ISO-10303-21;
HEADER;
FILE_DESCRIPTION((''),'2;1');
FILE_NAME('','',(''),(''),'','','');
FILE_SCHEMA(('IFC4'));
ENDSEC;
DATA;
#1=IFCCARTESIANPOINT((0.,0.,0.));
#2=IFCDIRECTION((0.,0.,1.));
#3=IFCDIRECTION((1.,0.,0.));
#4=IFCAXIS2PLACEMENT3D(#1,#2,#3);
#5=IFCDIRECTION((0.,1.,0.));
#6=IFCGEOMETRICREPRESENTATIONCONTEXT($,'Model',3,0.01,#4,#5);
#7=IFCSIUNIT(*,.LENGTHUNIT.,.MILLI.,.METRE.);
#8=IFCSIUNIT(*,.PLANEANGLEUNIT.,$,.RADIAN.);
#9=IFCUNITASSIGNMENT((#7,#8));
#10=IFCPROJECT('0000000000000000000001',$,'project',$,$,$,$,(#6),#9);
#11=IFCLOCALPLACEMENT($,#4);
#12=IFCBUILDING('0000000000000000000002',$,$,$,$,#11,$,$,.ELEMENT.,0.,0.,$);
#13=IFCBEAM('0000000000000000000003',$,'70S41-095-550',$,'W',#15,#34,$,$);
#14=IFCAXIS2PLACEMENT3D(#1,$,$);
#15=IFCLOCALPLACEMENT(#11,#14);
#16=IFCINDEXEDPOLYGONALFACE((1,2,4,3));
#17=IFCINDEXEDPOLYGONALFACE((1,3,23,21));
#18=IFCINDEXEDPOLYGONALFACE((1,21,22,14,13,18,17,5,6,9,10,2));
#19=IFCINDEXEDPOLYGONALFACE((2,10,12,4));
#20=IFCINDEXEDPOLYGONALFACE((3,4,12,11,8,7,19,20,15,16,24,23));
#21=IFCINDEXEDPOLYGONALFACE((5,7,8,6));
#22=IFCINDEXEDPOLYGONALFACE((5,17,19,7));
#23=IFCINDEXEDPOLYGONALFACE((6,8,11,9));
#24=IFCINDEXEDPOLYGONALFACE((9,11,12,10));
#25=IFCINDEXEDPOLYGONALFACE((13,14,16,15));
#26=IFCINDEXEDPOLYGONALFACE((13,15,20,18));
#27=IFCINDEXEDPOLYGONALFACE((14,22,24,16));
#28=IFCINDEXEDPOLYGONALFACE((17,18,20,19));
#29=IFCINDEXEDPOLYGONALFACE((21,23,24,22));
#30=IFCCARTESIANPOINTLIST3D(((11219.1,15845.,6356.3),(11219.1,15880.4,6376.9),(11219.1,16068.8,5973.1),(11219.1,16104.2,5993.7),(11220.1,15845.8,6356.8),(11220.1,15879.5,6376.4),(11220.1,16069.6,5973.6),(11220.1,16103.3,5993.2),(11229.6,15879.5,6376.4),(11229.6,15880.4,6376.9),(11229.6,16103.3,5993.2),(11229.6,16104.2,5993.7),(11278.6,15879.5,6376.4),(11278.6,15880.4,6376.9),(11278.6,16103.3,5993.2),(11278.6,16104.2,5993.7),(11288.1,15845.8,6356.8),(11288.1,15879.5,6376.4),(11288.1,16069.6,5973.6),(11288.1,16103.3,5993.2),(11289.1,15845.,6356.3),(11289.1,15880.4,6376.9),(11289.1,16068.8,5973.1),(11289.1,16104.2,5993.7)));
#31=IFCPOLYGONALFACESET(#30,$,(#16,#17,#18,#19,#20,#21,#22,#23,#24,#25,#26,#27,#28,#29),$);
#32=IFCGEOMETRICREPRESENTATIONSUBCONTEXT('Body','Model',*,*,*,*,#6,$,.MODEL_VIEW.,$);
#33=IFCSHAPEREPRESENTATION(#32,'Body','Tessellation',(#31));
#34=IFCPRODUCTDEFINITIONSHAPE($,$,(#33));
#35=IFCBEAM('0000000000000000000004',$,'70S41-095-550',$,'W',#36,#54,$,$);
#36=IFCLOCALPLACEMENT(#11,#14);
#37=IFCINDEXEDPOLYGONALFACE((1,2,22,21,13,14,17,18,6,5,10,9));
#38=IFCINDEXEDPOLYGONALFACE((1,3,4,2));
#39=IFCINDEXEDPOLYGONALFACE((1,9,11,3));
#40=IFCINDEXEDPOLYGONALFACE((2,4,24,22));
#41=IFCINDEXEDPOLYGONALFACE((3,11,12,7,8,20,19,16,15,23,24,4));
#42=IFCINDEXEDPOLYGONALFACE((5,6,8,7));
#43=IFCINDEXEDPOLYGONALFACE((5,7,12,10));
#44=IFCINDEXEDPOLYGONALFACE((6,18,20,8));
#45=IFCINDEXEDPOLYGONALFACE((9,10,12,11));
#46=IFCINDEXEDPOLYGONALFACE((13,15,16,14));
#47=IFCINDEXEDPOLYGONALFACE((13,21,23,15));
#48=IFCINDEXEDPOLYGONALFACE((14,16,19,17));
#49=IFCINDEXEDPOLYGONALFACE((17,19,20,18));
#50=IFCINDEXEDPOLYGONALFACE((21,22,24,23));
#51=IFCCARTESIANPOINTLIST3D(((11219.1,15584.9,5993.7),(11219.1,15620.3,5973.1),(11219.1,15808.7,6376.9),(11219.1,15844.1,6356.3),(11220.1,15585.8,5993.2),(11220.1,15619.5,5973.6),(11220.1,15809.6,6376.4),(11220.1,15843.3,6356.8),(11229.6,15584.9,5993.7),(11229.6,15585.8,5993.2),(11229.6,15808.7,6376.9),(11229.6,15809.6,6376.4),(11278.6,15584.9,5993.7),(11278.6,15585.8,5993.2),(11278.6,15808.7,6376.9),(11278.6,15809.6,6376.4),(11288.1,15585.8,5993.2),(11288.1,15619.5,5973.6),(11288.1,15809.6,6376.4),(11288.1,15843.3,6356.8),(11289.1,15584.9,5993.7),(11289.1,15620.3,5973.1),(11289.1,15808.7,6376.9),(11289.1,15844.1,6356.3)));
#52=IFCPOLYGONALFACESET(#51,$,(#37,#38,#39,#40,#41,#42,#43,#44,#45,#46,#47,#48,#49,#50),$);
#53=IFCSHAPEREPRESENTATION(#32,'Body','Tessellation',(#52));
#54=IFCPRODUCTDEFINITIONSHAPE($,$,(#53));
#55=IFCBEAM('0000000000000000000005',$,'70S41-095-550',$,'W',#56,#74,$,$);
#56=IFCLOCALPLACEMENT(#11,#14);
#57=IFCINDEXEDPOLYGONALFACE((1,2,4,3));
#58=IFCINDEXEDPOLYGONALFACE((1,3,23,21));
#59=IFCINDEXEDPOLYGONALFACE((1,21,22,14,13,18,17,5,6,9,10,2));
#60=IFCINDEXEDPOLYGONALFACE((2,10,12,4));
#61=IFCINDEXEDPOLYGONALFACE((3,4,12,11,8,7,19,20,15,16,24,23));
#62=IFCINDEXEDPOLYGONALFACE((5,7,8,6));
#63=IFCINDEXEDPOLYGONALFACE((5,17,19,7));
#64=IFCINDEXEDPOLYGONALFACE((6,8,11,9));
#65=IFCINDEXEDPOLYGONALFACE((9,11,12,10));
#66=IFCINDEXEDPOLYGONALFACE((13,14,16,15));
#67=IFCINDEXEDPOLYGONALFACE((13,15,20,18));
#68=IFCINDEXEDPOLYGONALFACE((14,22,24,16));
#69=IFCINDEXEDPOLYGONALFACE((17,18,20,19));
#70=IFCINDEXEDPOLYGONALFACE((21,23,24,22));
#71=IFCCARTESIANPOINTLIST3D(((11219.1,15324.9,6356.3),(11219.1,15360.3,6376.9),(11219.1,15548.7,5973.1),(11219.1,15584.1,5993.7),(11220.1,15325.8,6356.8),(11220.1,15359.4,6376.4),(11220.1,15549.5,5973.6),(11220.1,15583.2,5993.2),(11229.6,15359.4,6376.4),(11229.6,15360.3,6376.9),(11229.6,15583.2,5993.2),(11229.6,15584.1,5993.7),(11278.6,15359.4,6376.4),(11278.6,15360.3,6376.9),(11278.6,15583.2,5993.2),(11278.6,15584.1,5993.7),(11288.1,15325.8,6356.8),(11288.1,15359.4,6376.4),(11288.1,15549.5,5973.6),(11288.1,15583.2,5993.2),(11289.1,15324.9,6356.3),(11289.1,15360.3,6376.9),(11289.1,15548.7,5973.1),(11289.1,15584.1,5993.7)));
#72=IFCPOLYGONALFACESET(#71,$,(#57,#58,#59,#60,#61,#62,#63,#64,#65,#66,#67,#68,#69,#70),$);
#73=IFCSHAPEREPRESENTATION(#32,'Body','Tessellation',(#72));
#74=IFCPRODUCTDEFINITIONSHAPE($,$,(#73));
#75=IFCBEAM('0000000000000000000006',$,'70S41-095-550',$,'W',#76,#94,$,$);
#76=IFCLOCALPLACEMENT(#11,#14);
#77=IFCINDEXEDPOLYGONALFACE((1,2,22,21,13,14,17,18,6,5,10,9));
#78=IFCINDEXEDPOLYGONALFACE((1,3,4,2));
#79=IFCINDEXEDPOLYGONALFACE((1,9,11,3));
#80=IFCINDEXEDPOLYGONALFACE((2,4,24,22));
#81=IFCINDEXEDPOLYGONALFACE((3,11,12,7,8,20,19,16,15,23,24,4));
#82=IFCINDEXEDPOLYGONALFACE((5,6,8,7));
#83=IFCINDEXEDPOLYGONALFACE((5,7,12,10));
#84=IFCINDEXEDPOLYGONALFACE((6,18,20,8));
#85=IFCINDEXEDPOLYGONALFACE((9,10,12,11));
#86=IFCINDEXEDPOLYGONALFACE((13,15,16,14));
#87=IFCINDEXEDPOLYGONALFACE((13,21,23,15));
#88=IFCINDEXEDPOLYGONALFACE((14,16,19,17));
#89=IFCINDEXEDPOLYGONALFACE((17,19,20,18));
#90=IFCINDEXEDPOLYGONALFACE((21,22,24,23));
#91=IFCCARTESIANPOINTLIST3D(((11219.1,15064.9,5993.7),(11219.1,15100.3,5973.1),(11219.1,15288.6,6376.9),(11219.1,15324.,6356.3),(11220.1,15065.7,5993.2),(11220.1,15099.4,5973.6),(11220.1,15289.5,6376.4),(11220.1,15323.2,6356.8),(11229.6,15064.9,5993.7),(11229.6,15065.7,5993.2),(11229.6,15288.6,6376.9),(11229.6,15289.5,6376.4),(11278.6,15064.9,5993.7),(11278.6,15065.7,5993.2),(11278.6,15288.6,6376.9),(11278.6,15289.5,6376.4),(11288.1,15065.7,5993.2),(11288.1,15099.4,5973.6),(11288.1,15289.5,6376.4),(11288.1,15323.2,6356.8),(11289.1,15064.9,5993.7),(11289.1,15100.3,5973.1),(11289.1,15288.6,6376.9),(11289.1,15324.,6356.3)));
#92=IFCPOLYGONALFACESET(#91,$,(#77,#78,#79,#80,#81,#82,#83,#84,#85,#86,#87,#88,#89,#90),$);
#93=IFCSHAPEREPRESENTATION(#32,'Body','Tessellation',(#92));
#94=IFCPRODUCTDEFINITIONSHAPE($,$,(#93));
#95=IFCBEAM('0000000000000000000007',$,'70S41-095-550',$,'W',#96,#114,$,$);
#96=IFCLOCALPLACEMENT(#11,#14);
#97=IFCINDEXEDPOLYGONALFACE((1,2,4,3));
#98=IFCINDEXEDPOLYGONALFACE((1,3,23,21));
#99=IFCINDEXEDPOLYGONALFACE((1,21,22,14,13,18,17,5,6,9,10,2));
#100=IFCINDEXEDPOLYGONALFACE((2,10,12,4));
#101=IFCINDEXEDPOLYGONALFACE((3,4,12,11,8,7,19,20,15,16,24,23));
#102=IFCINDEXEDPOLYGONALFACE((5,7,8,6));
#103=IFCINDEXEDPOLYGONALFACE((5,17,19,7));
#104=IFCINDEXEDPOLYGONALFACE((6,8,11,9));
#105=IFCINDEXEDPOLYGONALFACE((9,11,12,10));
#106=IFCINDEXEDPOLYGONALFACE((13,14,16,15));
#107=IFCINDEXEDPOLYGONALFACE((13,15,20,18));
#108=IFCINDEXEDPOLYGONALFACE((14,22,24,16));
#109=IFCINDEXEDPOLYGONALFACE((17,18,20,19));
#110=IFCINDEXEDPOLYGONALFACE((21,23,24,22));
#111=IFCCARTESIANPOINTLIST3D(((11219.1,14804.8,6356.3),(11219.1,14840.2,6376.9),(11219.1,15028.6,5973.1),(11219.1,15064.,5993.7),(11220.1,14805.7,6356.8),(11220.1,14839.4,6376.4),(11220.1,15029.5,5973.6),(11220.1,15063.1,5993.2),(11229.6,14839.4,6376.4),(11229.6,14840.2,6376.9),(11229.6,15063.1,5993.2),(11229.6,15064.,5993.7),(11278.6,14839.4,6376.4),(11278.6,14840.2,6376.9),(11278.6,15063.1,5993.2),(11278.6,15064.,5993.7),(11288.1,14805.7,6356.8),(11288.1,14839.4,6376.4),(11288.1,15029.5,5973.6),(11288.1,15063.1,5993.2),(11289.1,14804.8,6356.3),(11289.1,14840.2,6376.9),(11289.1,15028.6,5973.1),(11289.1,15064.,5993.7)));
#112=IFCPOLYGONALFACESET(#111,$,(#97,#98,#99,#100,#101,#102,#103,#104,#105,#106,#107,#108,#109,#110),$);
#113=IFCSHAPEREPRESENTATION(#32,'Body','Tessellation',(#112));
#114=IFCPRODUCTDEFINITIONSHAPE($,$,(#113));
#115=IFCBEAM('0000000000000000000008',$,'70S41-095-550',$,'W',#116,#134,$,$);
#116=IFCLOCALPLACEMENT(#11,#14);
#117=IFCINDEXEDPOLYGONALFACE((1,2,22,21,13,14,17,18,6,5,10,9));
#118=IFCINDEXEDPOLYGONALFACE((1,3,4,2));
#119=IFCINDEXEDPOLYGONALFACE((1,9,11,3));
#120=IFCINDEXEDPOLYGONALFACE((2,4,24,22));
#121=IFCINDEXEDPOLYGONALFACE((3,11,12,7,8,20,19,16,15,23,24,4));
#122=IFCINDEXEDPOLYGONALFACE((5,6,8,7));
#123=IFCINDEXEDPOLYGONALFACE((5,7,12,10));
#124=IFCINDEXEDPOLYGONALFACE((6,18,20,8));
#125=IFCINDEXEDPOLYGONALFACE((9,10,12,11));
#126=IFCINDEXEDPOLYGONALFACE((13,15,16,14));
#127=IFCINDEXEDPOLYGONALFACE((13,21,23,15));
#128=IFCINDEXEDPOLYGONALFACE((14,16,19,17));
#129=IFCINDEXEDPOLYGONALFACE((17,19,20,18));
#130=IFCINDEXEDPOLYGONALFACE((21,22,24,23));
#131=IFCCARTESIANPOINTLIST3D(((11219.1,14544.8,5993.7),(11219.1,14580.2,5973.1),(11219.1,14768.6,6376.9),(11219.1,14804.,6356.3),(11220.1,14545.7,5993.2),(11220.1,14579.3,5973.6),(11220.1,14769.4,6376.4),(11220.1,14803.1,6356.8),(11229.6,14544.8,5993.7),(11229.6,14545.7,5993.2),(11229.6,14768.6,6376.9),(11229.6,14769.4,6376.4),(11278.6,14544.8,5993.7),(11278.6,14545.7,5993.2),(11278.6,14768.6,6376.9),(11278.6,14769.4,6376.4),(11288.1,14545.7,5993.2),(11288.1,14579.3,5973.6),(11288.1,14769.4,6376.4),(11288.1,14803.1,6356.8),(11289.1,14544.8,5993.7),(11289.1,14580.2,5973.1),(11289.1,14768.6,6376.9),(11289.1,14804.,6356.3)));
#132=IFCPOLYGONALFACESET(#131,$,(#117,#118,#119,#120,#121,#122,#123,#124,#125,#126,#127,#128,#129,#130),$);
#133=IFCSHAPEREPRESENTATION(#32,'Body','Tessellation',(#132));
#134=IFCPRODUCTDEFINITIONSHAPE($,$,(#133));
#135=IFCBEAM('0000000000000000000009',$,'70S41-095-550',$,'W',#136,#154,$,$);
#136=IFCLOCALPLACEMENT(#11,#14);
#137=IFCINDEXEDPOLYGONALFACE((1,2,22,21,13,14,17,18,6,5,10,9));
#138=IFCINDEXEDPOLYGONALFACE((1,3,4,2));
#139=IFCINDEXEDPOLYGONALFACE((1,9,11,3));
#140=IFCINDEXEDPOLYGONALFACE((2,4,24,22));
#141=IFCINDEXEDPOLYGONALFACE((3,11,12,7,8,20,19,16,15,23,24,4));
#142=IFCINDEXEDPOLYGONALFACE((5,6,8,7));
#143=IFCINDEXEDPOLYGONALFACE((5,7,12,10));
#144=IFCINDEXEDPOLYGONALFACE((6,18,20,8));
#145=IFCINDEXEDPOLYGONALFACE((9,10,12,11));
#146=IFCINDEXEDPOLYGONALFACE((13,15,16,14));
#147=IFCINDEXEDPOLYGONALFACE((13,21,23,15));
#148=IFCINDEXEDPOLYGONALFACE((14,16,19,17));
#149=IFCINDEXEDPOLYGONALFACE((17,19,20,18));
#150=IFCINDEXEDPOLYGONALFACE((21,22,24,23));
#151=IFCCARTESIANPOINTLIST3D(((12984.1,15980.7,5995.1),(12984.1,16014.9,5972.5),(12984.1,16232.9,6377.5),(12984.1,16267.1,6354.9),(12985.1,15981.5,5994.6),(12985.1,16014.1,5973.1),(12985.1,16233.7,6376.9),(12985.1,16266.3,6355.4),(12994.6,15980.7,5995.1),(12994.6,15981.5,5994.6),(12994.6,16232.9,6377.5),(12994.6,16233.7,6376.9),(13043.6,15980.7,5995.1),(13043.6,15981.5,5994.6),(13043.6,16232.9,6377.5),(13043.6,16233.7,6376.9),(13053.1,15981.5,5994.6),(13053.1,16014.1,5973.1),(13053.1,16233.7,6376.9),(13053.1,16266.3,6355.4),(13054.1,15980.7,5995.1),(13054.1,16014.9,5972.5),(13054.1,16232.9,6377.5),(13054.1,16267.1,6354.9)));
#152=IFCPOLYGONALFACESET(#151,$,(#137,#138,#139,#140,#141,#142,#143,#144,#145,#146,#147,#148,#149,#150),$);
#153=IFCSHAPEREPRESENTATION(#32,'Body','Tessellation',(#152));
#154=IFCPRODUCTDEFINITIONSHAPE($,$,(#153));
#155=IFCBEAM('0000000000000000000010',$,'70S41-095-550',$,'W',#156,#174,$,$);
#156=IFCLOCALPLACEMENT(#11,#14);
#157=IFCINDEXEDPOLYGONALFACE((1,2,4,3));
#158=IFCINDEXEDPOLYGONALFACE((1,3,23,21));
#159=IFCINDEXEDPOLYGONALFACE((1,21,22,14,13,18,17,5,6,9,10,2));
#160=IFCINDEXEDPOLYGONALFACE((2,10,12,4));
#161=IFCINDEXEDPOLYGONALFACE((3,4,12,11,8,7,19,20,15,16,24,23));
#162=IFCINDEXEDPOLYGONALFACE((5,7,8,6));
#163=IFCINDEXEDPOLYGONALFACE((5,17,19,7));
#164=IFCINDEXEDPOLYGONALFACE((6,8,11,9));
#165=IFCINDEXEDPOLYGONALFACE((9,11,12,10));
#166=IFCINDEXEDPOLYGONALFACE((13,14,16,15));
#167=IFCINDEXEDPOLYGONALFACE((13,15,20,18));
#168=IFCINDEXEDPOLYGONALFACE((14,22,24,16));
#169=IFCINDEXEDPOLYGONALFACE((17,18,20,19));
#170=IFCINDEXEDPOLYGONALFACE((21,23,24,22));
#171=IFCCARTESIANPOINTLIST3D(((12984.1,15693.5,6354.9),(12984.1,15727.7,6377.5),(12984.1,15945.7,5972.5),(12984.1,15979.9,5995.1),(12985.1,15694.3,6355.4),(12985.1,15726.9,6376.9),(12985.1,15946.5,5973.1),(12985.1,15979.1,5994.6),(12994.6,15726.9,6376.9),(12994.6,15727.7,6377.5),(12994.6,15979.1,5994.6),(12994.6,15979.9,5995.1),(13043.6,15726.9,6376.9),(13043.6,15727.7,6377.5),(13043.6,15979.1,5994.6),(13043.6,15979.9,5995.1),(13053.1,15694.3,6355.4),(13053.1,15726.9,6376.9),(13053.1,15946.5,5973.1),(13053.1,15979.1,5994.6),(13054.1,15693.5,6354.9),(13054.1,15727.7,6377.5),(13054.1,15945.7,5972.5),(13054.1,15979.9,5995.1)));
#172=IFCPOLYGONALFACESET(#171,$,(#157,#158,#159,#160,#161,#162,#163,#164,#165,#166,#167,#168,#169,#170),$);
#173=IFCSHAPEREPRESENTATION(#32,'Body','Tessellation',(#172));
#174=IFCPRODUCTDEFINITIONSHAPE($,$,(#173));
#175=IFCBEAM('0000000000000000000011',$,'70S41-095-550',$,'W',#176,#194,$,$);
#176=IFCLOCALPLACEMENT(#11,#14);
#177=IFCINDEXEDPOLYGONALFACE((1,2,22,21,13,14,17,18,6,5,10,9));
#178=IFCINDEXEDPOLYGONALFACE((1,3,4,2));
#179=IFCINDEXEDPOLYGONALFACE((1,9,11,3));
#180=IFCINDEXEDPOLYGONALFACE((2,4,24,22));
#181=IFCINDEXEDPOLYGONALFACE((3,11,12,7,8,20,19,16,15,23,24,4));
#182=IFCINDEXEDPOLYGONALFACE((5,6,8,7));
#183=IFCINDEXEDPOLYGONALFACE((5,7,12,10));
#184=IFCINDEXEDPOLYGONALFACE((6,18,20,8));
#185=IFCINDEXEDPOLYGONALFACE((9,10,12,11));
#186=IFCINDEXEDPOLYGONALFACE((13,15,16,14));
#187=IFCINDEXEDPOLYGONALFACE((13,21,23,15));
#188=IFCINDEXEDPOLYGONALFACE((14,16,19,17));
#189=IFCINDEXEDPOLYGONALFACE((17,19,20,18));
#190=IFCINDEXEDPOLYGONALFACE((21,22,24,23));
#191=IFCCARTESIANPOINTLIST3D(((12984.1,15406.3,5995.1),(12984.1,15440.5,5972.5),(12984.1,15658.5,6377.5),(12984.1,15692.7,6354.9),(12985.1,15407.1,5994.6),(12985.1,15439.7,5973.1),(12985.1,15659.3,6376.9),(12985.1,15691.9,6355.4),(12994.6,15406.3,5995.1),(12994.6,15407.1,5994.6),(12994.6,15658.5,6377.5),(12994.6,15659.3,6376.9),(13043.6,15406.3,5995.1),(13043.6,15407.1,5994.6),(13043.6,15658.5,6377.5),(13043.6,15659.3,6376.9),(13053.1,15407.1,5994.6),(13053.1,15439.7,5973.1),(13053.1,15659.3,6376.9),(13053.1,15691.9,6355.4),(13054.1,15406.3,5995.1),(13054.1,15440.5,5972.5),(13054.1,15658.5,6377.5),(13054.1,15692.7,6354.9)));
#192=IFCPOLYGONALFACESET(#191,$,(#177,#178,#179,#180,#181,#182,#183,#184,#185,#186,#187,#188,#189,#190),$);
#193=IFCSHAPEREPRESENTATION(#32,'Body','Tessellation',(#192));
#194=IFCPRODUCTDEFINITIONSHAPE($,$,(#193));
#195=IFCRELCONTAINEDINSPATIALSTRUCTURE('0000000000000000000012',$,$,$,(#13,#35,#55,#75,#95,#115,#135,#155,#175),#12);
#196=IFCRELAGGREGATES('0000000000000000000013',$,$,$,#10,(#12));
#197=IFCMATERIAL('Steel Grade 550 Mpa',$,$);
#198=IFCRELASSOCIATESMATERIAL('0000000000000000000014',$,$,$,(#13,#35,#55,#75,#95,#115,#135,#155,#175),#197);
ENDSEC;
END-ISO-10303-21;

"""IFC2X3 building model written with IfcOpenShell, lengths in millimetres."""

from ifc_helpers import new_model, si_unit, direction, frame, origin, origin_with_axes, origin_2d_with_axis, place, context, subcontext, project, spatial, c_section, extrude, source, transform, mapped, material, element, save


model = new_model("IFC2X3")

# Units and contexts
model_context = context("Model", 3, precision=0.01, world=origin_with_axes(), true_north=direction((0.0, 1.0, 0.0)))
body_context = subcontext(model_context, "Body", "Model", "MODEL_VIEW")
ifc_project = project(units=[si_unit("LENGTHUNIT", "METRE", prefix="MILLI"), si_unit("PLANEANGLEUNIT", "RADIAN")], contexts=[model_context])

# Building
building_placement = place(None, origin_with_axes())
building = spatial("IfcBuilding", under=ifc_project, at=building_placement, CompositionType="ELEMENT", ElevationOfRefHeight=0.0, ElevationOfTerrain=0.0)

# Beams
ifc_material = material(Name="Steel Grade 550 Mpa")
shared_shape_1 = source(origin(), body_context, "Body", "SweptSolid", [
    extrude(c_section(Depth=70.0, Width=41.0, WallThickness=1.0, Girth=10.5, at=origin_2d_with_axis()), origin_with_axes(), (0.0, 0.0, 1.0), 443.7),
])
beam_1_placement = place(None, frame((11254.1, 15862.7, 6366.6), z_axis=(0.0, 0.504288, -0.863535), x_axis=(0.0, 0.863535, 0.504288)))
element("IfcBeam", 1, at=beam_1_placement, inside=building, material=ifc_material, Name="70S41-095-550", ObjectType="W", context=body_context, shape_type="MappedRepresentation", body=[
    mapped(shared_shape_1, transform((0.0, 0.0, 0.0), scale=1.0)),
])
shared_shape_2 = source(origin(), body_context, "Body", "SweptSolid", [
    extrude(c_section(Depth=70.0, Width=41.0, WallThickness=1.0, Girth=10.5, at=origin_2d_with_axis()), origin_with_axes(), (0.0, 0.0, 1.0), 443.7),
])
beam_2_placement = place(None, frame((11254.1, 15602.6, 5983.4), z_axis=(0.0, 0.504288, 0.863535), x_axis=(0.0, -0.863535, 0.504288)))
element("IfcBeam", 2, at=beam_2_placement, inside=building, material=ifc_material, Name="70S41-095-550", ObjectType="W", context=body_context, shape_type="MappedRepresentation", body=[
    mapped(shared_shape_2, transform((0.0, 0.0, 0.0), scale=1.0)),
])
shared_shape_3 = source(origin(), body_context, "Body", "SweptSolid", [
    extrude(c_section(Depth=70.0, Width=41.0, WallThickness=1.0, Girth=10.5, at=origin_2d_with_axis()), origin_with_axes(), (0.0, 0.0, 1.0), 443.7),
])
beam_3_placement = place(None, frame((11254.1, 15342.6, 6366.6), z_axis=(0.0, 0.504288, -0.863535), x_axis=(0.0, 0.863535, 0.504288)))
element("IfcBeam", 3, at=beam_3_placement, inside=building, material=ifc_material, Name="70S41-095-550", ObjectType="W", context=body_context, shape_type="MappedRepresentation", body=[
    mapped(shared_shape_3, transform((0.0, 0.0, 0.0), scale=1.0)),
])
shared_shape_4 = source(origin(), body_context, "Body", "SweptSolid", [
    extrude(c_section(Depth=70.0, Width=41.0, WallThickness=1.0, Girth=10.5, at=origin_2d_with_axis()), origin_with_axes(), (0.0, 0.0, 1.0), 443.7),
])
beam_4_placement = place(None, frame((11254.1, 15082.6, 5983.4), z_axis=(0.0, 0.504288, 0.863535), x_axis=(0.0, -0.863535, 0.504288)))
element("IfcBeam", 4, at=beam_4_placement, inside=building, material=ifc_material, Name="70S41-095-550", ObjectType="W", context=body_context, shape_type="MappedRepresentation", body=[
    mapped(shared_shape_4, transform((0.0, 0.0, 0.0), scale=1.0)),
])
shared_shape_5 = source(origin(), body_context, "Body", "SweptSolid", [
    extrude(c_section(Depth=70.0, Width=41.0, WallThickness=1.0, Girth=10.5, at=origin_2d_with_axis()), origin_with_axes(), (0.0, 0.0, 1.0), 443.7),
])
beam_5_placement = place(None, frame((11254.1, 14822.5, 6366.6), z_axis=(0.0, 0.504288, -0.863535), x_axis=(0.0, 0.863535, 0.504288)))
element("IfcBeam", 5, at=beam_5_placement, inside=building, material=ifc_material, Name="70S41-095-550", ObjectType="W", context=body_context, shape_type="MappedRepresentation", body=[
    mapped(shared_shape_5, transform((0.0, 0.0, 0.0), scale=1.0)),
])
shared_shape_6 = source(origin(), body_context, "Body", "SweptSolid", [
    extrude(c_section(Depth=70.0, Width=41.0, WallThickness=1.0, Girth=10.5, at=origin_2d_with_axis()), origin_with_axes(), (0.0, 0.0, 1.0), 443.7),
])
beam_6_placement = place(None, frame((11254.1, 14562.5, 5983.4), z_axis=(0.0, 0.504288, 0.863535), x_axis=(0.0, -0.863535, 0.504288)))
element("IfcBeam", 6, at=beam_6_placement, inside=building, material=ifc_material, Name="70S41-095-550", ObjectType="W", context=body_context, shape_type="MappedRepresentation", body=[
    mapped(shared_shape_6, transform((0.0, 0.0, 0.0), scale=1.0)),
])
shared_shape_7 = source(origin(), body_context, "Body", "SweptSolid", [
    extrude(c_section(Depth=70.0, Width=41.0, WallThickness=1.0, Girth=10.5, at=origin_2d_with_axis()), origin_with_axes(), (0.0, 0.0, 1.0), 458.1),
])
beam_7_placement = place(None, frame((13019.1, 15997.8, 5983.8), z_axis=(0.0, 0.550611, 0.834762), x_axis=(0.0, -0.834762, 0.550611)))
element("IfcBeam", 7, at=beam_7_placement, inside=building, material=ifc_material, Name="70S41-095-550", ObjectType="W", context=body_context, shape_type="MappedRepresentation", body=[
    mapped(shared_shape_7, transform((0.0, 0.0, 0.0), scale=1.0)),
])
shared_shape_8 = source(origin(), body_context, "Body", "SweptSolid", [
    extrude(c_section(Depth=70.0, Width=41.0, WallThickness=1.0, Girth=10.5, at=origin_2d_with_axis()), origin_with_axes(), (0.0, 0.0, 1.0), 458.1),
])
beam_8_placement = place(None, frame((13019.1, 15710.6, 6366.2), z_axis=(0.0, 0.550611, -0.834762), x_axis=(0.0, 0.834762, 0.550611)))
element("IfcBeam", 8, at=beam_8_placement, inside=building, material=ifc_material, Name="70S41-095-550", ObjectType="W", context=body_context, shape_type="MappedRepresentation", body=[
    mapped(shared_shape_8, transform((0.0, 0.0, 0.0), scale=1.0)),
])
shared_shape_9 = source(origin(), body_context, "Body", "SweptSolid", [
    extrude(c_section(Depth=70.0, Width=41.0, WallThickness=1.0, Girth=10.5, at=origin_2d_with_axis()), origin_with_axes(), (0.0, 0.0, 1.0), 458.1),
])
beam_9_placement = place(None, frame((13019.1, 15423.4, 5983.8), z_axis=(0.0, 0.550611, 0.834762), x_axis=(0.0, -0.834762, 0.550611)))
element("IfcBeam", 9, at=beam_9_placement, inside=building, material=ifc_material, Name="70S41-095-550", ObjectType="W", context=body_context, shape_type="MappedRepresentation", body=[
    mapped(shared_shape_9, transform((0.0, 0.0, 0.0), scale=1.0)),
])

save(model, "model.ifc")
